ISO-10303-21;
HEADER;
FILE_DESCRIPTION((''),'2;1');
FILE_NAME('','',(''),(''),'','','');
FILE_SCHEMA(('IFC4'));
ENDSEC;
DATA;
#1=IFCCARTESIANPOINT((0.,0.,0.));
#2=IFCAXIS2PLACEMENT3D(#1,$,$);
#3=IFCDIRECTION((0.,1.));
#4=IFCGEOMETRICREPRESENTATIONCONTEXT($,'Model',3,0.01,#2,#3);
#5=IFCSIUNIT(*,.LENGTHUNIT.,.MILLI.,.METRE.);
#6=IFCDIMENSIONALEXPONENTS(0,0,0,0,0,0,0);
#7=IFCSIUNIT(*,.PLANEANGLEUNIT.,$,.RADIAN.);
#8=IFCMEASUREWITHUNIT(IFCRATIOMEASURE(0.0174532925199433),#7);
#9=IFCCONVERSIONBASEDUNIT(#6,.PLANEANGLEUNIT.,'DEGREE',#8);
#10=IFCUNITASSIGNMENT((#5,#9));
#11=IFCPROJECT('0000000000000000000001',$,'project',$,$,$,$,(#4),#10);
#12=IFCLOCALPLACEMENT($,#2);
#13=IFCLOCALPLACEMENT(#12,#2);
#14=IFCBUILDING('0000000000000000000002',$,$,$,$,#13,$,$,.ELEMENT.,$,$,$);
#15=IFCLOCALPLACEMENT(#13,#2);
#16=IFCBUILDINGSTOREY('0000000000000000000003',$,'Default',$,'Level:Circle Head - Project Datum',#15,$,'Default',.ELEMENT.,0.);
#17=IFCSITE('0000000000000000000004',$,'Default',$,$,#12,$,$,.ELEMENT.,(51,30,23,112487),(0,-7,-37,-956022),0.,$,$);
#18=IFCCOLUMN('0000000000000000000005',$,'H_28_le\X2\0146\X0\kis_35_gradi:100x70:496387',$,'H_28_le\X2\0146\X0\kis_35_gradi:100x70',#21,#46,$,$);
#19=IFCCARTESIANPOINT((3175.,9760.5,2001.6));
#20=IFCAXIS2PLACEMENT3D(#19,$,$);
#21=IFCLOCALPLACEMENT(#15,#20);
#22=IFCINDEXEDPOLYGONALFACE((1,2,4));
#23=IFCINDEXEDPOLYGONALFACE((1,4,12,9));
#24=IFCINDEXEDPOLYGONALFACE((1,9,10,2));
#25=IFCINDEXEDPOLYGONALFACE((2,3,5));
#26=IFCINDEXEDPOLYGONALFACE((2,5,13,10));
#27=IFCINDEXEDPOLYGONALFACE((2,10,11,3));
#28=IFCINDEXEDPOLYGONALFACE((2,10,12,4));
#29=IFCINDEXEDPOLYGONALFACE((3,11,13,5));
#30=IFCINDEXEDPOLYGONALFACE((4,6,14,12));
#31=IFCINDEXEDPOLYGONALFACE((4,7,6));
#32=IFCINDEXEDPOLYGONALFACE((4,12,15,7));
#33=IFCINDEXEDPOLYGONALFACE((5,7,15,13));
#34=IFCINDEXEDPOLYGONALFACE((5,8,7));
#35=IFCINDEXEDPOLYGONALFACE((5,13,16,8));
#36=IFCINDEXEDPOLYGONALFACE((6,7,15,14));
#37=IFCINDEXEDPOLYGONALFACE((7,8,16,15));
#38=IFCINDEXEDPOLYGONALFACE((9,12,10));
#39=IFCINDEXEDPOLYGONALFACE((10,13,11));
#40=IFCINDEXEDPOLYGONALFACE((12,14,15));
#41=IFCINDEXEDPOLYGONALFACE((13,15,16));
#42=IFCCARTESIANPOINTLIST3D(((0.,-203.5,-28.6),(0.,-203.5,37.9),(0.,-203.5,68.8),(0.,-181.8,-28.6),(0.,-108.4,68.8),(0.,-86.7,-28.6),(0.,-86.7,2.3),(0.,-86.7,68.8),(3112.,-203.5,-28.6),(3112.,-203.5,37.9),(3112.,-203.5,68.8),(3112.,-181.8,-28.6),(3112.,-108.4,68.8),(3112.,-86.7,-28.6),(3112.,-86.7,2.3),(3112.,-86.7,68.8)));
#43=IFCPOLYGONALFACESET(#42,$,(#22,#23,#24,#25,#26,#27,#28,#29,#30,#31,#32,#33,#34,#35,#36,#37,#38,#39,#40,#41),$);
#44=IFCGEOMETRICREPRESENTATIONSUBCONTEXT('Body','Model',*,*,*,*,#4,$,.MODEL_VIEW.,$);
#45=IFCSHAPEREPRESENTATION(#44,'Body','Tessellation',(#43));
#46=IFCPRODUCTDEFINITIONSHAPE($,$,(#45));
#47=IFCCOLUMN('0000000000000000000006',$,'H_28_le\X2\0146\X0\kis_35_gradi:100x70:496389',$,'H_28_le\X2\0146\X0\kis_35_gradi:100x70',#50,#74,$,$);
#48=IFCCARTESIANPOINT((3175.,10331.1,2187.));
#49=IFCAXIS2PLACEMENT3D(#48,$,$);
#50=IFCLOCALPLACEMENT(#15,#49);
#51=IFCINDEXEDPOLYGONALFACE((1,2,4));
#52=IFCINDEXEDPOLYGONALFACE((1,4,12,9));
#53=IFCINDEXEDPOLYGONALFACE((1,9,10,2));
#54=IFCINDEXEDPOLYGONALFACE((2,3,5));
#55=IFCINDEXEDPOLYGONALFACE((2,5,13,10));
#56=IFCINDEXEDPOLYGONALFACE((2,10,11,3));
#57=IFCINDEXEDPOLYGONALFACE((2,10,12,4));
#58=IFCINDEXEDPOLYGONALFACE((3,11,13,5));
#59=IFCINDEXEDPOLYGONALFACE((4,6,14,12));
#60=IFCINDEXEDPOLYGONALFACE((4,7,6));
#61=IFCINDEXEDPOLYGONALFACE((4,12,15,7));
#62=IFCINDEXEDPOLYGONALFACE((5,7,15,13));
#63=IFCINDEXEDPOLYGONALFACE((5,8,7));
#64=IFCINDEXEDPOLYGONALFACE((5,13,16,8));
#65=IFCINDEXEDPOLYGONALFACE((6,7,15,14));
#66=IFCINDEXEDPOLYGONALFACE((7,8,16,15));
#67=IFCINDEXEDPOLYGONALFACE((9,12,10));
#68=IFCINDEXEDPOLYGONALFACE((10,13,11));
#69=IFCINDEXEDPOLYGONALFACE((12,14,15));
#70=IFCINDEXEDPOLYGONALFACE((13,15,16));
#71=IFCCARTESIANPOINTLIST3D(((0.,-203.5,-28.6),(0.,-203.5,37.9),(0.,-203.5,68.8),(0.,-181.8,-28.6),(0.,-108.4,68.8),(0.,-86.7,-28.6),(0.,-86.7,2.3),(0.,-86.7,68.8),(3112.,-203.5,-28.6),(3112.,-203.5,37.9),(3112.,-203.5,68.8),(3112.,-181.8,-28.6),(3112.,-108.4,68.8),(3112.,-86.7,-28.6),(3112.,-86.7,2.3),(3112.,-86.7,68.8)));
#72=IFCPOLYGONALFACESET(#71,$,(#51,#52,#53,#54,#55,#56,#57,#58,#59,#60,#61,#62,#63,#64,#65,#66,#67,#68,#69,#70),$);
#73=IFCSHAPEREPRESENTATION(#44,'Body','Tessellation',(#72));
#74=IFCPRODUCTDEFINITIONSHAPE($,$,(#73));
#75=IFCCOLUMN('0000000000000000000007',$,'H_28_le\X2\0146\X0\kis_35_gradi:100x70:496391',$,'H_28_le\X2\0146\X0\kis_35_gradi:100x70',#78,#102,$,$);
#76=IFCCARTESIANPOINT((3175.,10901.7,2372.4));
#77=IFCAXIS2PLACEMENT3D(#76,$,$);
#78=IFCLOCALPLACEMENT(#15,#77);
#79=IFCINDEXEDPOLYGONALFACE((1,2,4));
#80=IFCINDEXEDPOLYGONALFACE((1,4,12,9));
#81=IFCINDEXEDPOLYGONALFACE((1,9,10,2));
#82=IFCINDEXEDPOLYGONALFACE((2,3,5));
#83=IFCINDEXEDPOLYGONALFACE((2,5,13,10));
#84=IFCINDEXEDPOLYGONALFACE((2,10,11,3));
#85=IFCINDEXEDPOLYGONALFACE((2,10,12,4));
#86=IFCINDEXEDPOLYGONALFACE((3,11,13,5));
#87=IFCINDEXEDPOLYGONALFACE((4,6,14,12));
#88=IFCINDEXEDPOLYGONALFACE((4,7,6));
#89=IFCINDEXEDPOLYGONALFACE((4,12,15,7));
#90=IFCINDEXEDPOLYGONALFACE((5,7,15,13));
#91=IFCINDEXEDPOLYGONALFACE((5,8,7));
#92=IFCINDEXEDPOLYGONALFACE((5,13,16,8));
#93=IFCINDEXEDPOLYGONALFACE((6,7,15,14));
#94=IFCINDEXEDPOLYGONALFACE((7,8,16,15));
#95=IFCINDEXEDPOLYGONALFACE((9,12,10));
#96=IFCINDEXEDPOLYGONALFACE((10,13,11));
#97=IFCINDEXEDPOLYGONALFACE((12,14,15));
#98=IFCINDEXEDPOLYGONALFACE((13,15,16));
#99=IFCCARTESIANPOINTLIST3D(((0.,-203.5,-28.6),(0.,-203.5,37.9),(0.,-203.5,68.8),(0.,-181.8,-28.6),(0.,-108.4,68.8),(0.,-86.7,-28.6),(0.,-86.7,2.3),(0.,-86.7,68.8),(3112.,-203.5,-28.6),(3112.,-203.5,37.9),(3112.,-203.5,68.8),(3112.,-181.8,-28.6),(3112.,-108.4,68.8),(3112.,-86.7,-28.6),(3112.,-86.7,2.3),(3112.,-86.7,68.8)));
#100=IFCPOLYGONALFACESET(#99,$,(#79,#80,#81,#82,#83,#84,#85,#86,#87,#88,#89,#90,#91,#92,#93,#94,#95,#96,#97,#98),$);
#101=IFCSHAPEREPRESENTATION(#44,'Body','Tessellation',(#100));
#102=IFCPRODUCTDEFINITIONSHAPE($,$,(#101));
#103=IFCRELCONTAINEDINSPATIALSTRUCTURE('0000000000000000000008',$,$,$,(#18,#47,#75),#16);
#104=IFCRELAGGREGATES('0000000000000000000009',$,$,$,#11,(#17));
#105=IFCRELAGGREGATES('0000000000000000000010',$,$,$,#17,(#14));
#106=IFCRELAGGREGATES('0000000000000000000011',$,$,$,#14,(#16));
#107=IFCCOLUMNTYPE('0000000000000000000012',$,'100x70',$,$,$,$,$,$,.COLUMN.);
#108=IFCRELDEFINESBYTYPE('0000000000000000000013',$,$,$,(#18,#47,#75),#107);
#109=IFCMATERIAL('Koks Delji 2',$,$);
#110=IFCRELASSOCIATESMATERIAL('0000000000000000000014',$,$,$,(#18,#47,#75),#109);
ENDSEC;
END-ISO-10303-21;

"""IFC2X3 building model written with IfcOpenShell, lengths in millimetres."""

from ifc_helpers import new_model, entity, si_unit, converted_unit, direction, frame, frame_2d, origin, origin_2d_with_axis, place, context, subcontext, project, spatial, rectangle, extrude, boolean, source, transform, mapped, material, type_object, type_shapes, element, save


model = new_model("IFC2X3")

# Units and contexts
model_context = context("Model", 3, precision=0.01, world=origin(), true_north=direction((0.0, 1.0)))
body_context = subcontext(model_context, "Body", "Model", "MODEL_VIEW")
ifc_project = project(units=[si_unit("LENGTHUNIT", "METRE", prefix="MILLI"), converted_unit("PLANEANGLEUNIT", "DEGREE", entity("IfcRatioMeasure", 0.0174532925199433), si_unit("PLANEANGLEUNIT", "RADIAN"), dimensions=[0, 0, 0, 0, 0, 0, 0])], contexts=[model_context])

# Site, building, storey
site_placement = place(None, origin())
site = spatial("IfcSite", under=ifc_project, at=site_placement, Name="Default", CompositionType="ELEMENT", RefLatitude=(51, 30, 23, 112487), RefLongitude=(0, -7, -37, -956022), RefElevation=0.0)
building_placement = place(site_placement, origin())
building = spatial("IfcBuilding", under=site, at=building_placement, CompositionType="ELEMENT")
storey_placement = place(building_placement, origin())
storey = spatial("IfcBuildingStorey", under=building, at=storey_placement, Name="Default", ObjectType="Level:Circle Head - Project Datum", LongName="Default", CompositionType="ELEMENT", Elevation=0.0)

# Columns
ifc_material_1 = material(Name="Koks Delji 2")
column_type = type_object("IfcColumnType", Name="100x70", PredefinedType="COLUMN")
shared_shape_1 = source(origin(), body_context, "Body", "CSG", [
    boolean("DIFFERENCE", extrude(rectangle(XDim=3112.0, YDim=116.7, at=origin_2d_with_axis()), frame((1556.0, -145.1, -28.6)), (0.0, 0.0, 1.0), 97.5), extrude(rectangle(XDim=70.0, YDim=100.0, at=frame_2d((0.0, 0.0), x_axis=(0.0, 1.0))), frame((0.0, -145.1, 20.1), z_axis=(-1.0, 0.0, 0.0), x_axis=(0.0, -0.951057, -0.309017)), (0.0, 0.0, -1.0), 3112.0)),
])
type_shapes(column_type, [shared_shape_1])
for number, where, name in (
    (1, (3175.0, 9760.5, 2001.6), "H_28_leņkis_35_gradi:100x70:496387"),
    (2, (3175.0, 10331.1, 2187.0), "H_28_leņkis_35_gradi:100x70:496389"),
    (3, (3175.0, 10901.7, 2372.4), "H_28_leņkis_35_gradi:100x70:496391"),
):
    element("IfcColumn", number, at=place(storey_placement, frame(where)), inside=storey, type_object=column_type, material=ifc_material_1, Name=name, ObjectType="H_28_leņkis_35_gradi:100x70", context=body_context, shape_type="MappedRepresentation", body=[
        mapped(shared_shape_1, transform((0.0, 0.0, 0.0), scale=1.0)),
    ])

save(model, "model.ifc")
